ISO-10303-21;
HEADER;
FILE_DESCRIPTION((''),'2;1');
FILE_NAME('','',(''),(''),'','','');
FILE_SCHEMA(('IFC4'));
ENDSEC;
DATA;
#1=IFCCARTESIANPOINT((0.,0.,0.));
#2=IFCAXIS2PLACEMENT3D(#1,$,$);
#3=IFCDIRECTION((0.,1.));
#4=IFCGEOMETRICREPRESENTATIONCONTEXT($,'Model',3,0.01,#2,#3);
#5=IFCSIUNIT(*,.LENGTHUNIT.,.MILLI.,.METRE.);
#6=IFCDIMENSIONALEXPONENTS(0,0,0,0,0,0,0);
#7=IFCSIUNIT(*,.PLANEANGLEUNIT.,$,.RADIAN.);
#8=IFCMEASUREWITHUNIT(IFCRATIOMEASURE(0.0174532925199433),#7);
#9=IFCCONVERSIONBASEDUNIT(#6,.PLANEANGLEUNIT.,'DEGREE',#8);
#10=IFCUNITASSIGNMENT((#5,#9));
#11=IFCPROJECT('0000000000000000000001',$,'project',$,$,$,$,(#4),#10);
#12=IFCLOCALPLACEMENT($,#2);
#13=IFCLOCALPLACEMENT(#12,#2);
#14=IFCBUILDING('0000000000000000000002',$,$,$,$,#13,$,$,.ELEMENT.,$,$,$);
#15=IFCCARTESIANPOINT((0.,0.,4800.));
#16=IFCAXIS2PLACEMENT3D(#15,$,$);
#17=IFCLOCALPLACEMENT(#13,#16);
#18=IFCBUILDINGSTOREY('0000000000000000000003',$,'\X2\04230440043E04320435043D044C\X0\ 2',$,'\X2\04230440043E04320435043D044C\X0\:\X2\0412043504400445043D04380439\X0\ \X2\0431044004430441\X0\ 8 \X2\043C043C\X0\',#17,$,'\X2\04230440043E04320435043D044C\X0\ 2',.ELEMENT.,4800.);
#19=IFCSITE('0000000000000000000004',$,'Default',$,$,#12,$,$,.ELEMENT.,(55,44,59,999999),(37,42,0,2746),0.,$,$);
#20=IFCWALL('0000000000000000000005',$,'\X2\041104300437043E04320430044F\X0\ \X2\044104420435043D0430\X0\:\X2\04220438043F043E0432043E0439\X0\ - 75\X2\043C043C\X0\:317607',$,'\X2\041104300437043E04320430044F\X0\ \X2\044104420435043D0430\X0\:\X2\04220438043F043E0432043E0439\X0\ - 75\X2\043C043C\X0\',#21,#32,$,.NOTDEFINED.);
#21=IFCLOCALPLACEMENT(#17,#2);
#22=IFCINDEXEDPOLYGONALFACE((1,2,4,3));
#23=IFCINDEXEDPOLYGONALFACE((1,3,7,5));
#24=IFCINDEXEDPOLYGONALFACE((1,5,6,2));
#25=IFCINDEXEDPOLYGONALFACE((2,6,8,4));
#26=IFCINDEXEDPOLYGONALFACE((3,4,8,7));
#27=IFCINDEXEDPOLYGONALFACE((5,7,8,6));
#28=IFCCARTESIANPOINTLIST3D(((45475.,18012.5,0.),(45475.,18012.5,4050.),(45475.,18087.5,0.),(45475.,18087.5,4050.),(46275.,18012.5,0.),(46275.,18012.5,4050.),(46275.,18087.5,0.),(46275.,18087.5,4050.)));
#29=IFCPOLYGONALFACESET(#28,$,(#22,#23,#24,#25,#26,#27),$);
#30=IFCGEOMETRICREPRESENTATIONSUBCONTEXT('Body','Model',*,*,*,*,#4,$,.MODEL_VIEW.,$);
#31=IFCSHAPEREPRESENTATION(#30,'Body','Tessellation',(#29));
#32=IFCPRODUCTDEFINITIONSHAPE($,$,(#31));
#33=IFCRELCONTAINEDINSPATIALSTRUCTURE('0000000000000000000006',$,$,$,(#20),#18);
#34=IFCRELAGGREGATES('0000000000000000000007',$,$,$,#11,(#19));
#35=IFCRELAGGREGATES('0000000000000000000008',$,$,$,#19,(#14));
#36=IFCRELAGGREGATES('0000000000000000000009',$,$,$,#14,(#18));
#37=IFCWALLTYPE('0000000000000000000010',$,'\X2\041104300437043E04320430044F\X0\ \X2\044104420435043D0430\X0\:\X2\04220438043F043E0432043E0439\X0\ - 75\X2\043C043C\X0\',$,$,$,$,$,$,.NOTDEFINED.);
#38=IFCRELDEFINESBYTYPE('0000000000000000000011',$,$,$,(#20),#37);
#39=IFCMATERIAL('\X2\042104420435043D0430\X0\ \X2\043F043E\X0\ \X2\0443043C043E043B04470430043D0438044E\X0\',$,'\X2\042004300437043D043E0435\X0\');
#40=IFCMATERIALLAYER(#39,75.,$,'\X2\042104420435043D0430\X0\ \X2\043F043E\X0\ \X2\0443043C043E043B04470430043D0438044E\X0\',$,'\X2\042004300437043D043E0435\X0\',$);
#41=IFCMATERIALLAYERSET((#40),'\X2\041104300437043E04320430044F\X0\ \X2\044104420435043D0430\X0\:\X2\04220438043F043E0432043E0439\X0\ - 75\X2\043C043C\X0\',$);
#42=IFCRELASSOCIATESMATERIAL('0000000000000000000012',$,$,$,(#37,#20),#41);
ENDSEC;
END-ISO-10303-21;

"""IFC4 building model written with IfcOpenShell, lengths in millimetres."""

from ifc_helpers import new_model, entity, si_unit, converted_unit, direction, frame, frame_2d, origin, place, context, subcontext, project, spatial, rectangle, extrude, material, layer, layer_set, layer_usage, type_object, element, save


model = new_model("IFC4")

# Units and contexts
model_context = context("Model", 3, precision=0.01, world=origin(), true_north=direction((0.0, 1.0)))
body_context = subcontext(model_context, "Body", "Model", "MODEL_VIEW")
ifc_project = project(units=[si_unit("LENGTHUNIT", "METRE", prefix="MILLI"), converted_unit("PLANEANGLEUNIT", "DEGREE", entity("IfcRatioMeasure", 0.0174532925199433), si_unit("PLANEANGLEUNIT", "RADIAN"), dimensions=[0, 0, 0, 0, 0, 0, 0])], contexts=[model_context])

# Site, building, storey
site_placement = place(None, origin())
site = spatial("IfcSite", under=ifc_project, at=site_placement, Name="Default", CompositionType="ELEMENT", RefLatitude=(55, 44, 59, 999999), RefLongitude=(37, 42, 0, 2746), RefElevation=0.0)
building_placement = place(site_placement, origin())
building = spatial("IfcBuilding", under=site, at=building_placement, CompositionType="ELEMENT")
storey_placement = place(building_placement, frame((0.0, 0.0, 4800.0)))
storey = spatial("IfcBuildingStorey", under=building, at=storey_placement, Name="Уровень 2", ObjectType="Уровень:Верхний брус 8 мм", LongName="Уровень 2", CompositionType="ELEMENT", Elevation=4800.0)

# Shared definitions
ifc_material_1 = material(Name="Стена по умолчанию", Category="Разное")

# Wall
ifc_layer_1 = layer(ifc_material_1, 75.0, Name="Стена по умолчанию", Category="Разное")
ifc_layer_set_1 = layer_set([ifc_layer_1], Name="Базовая стена:Типовой - 75мм")
wall_type_1 = type_object("IfcWallType", Name="Базовая стена:Типовой - 75мм", PredefinedType="NOTDEFINED", material=ifc_layer_set_1)
ifc_layer_usage_1 = layer_usage(ifc_layer_set_1, "AXIS2", "NEGATIVE", 37.5)
wall_1_placement = place(storey_placement, frame((45475.0, 18050.0, 0.0)))
element("IfcWall", 1, at=wall_1_placement, inside=storey, type_object=wall_type_1, material=ifc_layer_usage_1, Name="Базовая стена:Типовой - 75мм:317607", ObjectType="Базовая стена:Типовой - 75мм", PredefinedType="NOTDEFINED", context=body_context, shape_type="SweptSolid", body=[
    extrude(rectangle(XDim=800.0, YDim=75.0, at=frame_2d((400.0, 0.0), x_axis=(-1.0, 0.0))), origin(), (0.0, 0.0, 1.0), 4050.0),
])

save(model, "model.ifc")
